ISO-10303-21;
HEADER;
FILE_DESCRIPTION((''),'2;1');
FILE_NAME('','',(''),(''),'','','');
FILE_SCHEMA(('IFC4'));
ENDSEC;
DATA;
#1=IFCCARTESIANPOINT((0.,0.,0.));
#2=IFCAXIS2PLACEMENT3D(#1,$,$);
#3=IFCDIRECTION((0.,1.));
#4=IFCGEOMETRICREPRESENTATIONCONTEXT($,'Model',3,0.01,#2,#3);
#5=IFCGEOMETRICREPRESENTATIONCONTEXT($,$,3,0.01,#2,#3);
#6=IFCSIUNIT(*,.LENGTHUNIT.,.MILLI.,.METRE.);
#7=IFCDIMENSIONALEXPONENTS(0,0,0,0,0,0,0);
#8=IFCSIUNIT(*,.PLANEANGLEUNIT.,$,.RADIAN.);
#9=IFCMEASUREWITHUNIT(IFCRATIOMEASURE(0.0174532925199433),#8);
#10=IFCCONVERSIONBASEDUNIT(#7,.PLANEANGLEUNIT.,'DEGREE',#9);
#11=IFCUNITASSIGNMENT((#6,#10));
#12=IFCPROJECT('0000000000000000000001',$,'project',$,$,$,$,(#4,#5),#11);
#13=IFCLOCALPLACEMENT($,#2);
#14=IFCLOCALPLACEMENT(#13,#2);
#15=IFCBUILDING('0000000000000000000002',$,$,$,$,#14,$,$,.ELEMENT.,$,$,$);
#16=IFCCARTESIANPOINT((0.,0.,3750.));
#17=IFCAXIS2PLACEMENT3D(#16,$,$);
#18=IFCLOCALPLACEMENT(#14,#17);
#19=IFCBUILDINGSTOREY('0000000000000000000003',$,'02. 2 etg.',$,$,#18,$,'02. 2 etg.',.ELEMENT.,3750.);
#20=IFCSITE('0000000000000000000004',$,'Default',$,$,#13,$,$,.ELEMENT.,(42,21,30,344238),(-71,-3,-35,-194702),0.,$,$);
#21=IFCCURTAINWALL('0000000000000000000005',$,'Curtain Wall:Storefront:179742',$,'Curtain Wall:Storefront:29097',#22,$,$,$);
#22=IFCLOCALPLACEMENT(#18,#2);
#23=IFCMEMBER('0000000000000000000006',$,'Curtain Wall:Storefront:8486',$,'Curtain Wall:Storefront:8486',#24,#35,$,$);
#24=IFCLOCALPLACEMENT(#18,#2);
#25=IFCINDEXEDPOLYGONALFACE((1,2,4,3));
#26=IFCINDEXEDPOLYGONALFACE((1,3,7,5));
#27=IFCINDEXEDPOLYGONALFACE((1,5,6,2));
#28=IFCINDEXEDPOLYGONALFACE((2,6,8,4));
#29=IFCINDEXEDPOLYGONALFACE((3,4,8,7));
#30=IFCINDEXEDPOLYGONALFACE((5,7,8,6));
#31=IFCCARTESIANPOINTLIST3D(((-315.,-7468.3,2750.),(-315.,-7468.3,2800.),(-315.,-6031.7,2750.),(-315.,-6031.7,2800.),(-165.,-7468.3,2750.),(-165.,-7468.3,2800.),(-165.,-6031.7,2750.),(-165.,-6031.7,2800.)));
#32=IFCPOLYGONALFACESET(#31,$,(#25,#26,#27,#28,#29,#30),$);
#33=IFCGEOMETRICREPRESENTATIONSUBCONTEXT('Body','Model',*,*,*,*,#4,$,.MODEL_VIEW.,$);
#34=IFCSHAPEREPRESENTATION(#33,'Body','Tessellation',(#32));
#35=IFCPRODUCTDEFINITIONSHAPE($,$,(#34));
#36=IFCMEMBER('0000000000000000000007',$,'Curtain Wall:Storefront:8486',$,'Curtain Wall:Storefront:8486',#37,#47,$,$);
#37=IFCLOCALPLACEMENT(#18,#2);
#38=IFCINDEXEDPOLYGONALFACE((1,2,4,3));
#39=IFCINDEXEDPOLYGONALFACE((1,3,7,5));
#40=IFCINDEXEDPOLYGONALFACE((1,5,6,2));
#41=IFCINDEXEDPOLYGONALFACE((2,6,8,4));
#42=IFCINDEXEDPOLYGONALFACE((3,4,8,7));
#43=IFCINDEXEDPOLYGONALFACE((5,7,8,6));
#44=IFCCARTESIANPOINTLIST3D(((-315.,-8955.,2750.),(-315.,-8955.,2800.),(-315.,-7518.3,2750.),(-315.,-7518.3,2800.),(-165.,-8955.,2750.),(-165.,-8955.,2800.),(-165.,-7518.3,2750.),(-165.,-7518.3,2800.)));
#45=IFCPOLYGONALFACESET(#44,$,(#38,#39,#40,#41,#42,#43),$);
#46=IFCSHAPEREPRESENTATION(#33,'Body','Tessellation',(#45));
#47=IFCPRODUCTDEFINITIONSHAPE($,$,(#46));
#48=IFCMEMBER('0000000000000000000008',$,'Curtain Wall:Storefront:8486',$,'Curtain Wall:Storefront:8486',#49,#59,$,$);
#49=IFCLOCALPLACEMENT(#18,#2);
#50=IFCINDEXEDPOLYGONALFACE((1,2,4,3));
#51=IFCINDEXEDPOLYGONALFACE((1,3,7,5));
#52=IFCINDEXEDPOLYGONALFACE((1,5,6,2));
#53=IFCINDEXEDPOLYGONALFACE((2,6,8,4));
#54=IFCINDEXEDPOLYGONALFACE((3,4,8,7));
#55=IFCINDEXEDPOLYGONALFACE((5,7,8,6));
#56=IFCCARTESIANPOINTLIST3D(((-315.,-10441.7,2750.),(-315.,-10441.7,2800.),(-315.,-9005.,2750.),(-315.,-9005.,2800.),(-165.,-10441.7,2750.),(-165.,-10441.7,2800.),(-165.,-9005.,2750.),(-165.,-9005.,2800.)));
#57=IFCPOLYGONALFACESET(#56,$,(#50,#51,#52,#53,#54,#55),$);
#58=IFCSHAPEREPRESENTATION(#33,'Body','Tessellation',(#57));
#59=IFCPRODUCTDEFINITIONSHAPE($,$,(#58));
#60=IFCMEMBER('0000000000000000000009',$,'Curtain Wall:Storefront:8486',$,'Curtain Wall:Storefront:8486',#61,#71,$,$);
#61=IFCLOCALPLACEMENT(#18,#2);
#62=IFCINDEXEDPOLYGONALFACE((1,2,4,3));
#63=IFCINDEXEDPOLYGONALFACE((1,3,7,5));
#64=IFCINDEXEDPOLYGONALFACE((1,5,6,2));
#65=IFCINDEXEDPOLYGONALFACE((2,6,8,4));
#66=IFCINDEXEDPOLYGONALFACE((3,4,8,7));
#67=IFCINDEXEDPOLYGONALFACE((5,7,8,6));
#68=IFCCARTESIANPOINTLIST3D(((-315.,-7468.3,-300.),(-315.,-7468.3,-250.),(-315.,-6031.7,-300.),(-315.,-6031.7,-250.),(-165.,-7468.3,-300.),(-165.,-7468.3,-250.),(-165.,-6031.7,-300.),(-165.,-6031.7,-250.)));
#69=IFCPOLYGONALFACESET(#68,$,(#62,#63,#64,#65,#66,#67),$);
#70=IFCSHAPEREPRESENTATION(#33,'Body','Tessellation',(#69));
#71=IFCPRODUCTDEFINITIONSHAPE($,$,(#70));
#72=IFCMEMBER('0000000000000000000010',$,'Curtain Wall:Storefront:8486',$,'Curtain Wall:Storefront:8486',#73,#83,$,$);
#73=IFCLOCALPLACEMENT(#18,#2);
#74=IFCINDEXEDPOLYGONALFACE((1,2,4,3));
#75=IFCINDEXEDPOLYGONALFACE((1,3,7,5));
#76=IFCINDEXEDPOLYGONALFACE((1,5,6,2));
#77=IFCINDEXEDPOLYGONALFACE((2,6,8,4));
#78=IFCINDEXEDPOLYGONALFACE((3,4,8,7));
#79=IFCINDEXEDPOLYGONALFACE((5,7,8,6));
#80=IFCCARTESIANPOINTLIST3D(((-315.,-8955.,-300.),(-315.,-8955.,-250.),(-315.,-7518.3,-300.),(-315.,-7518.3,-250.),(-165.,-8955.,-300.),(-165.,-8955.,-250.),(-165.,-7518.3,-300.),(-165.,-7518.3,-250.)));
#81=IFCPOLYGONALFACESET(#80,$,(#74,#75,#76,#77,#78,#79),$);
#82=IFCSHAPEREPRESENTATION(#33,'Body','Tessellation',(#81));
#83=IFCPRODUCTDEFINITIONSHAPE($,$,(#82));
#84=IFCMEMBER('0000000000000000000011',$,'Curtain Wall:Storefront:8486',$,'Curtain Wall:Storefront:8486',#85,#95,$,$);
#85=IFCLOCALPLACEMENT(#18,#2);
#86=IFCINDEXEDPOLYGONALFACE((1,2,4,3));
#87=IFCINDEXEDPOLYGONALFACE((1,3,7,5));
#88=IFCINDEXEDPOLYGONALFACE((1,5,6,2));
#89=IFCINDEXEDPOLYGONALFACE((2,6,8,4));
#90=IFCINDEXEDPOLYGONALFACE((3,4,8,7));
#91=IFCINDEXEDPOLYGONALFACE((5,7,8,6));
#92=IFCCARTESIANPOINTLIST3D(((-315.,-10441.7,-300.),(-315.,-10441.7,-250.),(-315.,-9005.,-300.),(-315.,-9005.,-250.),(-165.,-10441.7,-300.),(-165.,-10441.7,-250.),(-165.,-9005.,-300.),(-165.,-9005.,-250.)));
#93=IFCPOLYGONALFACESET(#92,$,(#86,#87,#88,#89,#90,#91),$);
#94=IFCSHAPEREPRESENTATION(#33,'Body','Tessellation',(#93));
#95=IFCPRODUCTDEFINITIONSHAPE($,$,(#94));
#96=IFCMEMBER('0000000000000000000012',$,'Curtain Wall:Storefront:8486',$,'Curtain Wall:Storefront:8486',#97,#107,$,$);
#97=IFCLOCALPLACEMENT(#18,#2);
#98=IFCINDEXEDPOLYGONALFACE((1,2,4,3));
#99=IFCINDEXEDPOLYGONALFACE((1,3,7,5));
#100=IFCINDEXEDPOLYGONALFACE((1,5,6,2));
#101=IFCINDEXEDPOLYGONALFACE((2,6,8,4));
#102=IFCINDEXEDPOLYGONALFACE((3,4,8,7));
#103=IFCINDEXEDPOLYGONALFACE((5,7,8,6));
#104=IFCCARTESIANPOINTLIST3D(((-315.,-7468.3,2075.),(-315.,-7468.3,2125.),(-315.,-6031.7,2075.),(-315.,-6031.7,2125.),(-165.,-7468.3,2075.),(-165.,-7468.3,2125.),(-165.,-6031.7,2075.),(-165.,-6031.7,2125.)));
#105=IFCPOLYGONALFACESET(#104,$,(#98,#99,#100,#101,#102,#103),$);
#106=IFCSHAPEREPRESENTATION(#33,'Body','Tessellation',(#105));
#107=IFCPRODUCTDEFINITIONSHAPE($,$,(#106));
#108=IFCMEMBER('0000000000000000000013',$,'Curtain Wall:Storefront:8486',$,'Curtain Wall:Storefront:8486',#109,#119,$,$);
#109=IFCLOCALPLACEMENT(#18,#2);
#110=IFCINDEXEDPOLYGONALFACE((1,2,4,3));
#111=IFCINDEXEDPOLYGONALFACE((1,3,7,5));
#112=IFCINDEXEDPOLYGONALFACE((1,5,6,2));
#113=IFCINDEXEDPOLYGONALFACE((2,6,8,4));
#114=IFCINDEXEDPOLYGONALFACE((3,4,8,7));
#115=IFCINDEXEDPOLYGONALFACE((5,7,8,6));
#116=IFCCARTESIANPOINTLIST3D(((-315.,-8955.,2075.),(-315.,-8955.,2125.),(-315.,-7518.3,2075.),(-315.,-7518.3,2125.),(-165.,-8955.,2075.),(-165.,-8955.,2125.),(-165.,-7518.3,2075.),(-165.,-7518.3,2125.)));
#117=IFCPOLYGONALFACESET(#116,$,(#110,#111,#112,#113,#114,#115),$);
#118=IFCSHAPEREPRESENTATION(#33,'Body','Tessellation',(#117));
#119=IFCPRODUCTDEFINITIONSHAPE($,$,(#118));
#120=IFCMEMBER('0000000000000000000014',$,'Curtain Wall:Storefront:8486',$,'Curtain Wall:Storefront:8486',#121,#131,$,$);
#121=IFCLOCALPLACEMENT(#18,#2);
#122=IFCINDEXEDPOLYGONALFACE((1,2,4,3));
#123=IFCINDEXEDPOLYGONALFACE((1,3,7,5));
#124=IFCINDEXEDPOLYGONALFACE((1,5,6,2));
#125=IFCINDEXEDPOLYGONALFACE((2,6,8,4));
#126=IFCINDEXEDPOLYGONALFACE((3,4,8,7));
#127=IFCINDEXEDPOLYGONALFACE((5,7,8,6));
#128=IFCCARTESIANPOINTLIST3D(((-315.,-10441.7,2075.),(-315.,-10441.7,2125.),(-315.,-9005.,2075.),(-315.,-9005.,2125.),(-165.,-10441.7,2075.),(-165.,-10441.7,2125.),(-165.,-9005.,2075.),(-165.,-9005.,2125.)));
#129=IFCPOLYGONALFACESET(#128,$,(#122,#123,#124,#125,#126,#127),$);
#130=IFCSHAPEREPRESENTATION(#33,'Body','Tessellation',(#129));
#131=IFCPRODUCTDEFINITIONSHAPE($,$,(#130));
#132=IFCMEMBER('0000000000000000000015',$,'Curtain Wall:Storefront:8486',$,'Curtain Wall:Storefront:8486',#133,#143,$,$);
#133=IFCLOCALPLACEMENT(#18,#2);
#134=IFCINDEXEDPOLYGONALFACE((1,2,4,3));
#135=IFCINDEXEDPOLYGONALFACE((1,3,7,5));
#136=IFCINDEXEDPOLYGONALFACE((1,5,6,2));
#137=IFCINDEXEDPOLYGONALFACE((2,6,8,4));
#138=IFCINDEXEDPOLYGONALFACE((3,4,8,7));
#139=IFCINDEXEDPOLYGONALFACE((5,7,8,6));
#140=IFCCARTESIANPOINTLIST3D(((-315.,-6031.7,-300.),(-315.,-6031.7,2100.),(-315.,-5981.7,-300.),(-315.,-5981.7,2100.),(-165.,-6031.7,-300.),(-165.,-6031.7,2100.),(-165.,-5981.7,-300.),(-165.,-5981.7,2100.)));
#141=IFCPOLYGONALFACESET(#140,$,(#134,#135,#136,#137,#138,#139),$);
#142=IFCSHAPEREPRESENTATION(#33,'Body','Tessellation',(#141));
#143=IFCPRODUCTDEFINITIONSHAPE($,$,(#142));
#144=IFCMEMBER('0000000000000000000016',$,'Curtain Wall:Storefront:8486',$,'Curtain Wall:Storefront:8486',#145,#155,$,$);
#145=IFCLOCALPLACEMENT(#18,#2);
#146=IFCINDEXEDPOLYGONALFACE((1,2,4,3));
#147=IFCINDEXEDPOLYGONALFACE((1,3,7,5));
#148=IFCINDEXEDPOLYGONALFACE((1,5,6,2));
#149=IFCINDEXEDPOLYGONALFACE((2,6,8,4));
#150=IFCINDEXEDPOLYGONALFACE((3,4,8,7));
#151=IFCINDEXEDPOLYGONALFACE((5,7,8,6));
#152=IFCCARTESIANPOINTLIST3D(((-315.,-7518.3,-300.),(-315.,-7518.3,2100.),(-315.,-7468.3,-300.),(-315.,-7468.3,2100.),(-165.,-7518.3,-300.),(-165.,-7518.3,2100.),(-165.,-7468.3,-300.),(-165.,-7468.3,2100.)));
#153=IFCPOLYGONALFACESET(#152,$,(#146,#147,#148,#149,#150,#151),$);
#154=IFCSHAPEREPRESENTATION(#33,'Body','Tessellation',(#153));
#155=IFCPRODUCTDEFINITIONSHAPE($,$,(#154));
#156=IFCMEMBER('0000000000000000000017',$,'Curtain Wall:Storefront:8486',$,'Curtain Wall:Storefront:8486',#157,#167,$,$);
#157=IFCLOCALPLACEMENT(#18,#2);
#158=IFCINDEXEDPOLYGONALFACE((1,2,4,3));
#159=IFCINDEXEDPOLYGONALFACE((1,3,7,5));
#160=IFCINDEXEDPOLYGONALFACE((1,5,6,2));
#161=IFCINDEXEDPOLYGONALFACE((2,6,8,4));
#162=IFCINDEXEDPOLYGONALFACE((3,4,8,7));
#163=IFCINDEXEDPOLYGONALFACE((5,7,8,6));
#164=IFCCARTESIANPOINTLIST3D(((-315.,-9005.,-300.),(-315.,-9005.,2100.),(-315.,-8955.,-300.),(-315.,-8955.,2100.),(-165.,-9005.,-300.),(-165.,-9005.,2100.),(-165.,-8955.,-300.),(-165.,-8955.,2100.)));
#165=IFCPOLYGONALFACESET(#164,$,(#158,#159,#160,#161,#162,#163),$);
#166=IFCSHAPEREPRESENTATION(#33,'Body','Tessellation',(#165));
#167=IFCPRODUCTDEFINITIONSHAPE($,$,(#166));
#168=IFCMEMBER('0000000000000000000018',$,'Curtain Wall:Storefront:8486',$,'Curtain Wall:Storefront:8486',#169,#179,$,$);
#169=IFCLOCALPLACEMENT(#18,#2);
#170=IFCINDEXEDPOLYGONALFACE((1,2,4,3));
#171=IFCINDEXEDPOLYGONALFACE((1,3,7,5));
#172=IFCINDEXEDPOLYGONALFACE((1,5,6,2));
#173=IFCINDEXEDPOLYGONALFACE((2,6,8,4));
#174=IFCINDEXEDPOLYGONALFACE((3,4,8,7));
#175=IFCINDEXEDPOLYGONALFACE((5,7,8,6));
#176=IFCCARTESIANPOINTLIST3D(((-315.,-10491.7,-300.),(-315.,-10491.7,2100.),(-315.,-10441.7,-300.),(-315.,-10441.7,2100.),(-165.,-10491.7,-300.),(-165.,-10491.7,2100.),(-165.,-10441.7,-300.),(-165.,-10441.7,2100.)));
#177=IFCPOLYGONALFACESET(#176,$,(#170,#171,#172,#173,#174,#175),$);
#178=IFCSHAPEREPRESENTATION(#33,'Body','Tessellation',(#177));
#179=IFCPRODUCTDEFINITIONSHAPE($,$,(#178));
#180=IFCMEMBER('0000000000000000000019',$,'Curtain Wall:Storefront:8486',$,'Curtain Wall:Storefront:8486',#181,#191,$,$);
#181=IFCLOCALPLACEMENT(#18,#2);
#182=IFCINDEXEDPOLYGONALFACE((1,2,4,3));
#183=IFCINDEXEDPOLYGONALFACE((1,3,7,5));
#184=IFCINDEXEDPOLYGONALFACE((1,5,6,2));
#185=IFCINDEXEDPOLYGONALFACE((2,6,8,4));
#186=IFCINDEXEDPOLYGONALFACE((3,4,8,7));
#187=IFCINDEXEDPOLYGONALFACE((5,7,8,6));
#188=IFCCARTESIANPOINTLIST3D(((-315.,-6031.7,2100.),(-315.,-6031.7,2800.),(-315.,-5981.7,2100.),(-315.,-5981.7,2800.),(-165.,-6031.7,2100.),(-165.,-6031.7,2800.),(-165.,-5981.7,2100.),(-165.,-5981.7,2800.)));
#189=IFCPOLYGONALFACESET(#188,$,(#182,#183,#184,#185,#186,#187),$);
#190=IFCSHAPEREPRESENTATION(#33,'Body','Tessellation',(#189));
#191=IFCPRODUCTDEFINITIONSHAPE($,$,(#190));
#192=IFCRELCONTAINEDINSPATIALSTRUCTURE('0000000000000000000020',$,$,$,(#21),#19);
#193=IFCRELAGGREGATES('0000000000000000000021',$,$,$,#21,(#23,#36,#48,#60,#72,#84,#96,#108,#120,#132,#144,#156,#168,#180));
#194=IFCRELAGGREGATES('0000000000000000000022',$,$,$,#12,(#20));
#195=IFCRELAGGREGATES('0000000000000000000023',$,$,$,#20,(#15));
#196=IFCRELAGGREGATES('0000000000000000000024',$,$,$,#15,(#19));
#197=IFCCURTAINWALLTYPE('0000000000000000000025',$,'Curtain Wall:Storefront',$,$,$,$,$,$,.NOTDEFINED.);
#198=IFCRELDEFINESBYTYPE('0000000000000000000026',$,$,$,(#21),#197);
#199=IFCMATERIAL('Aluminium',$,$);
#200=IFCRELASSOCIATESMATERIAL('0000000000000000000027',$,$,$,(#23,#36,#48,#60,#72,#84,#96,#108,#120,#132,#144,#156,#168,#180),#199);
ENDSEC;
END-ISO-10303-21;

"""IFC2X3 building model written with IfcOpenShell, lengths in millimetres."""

from ifc_helpers import new_model, entity, si_unit, converted_unit, direction, frame, frame_2d, origin, origin_2d_with_axis, place, context, subcontext, project, spatial, rectangle, extrude, material, type_object, element, aggregate, save


model = new_model("IFC2X3")

# Units and contexts
model_context = context("Model", 3, precision=0.01, world=origin(), true_north=direction((0.0, 1.0)))
context_of_model = context(None, 3, precision=0.01, world=origin(), true_north=direction((0.0, 1.0)))
body_context = subcontext(model_context, "Body", "Model", "MODEL_VIEW")
ifc_project = project(units=[si_unit("LENGTHUNIT", "METRE", prefix="MILLI"), converted_unit("PLANEANGLEUNIT", "DEGREE", entity("IfcRatioMeasure", 0.0174532925199433), si_unit("PLANEANGLEUNIT", "RADIAN"), dimensions=[0, 0, 0, 0, 0, 0, 0])], contexts=[model_context, context_of_model])

# Site, building, storey
site_placement = place(None, origin())
site = spatial("IfcSite", under=ifc_project, at=site_placement, Name="Default", CompositionType="ELEMENT", RefLatitude=(42, 21, 30, 344238), RefLongitude=(-71, -3, -35, -194702), RefElevation=0.0)
building_placement = place(site_placement, origin())
building = spatial("IfcBuilding", under=site, at=building_placement, CompositionType="ELEMENT")
storey_placement = place(building_placement, frame((0.0, 0.0, 3750.0)))
storey = spatial("IfcBuildingStorey", under=building, at=storey_placement, Name="02. 2 etg.", LongName="02. 2 etg.", CompositionType="ELEMENT", Elevation=3750.0)

# Curtain wall, members
curtain_wall_type = type_object("IfcCurtainWallType", Name="Curtain Wall:Storefront", PredefinedType="NOTDEFINED")
curtain_wall_placement = place(storey_placement, frame((0.0, 0.0, -3750.0)))
curtain_wall = element("IfcCurtainWall", 1, at=curtain_wall_placement, inside=storey, type_object=curtain_wall_type, Name="Curtain Wall:Storefront:179742", ObjectType="Curtain Wall:Storefront:29097")
ifc_material_1 = material(Name="Aluminium")
member_1_placement = place(curtain_wall_placement, frame((-315.0, -7468.3, 6500.0)))
member_1 = element("IfcMember", 2, at=member_1_placement, material=ifc_material_1, Name="Curtain Wall:Storefront:8486", ObjectType="Curtain Wall:Storefront:8486", context=body_context, shape_type="SweptSolid", body=[
    extrude(rectangle(XDim=1436.7, YDim=150.0, at=frame_2d((0.0, 0.0), x_axis=(1.0, 0.0))), frame((75.0, 718.3, 0.0), z_axis=(0.0, 0.0, 1.0), x_axis=(0.0, 1.0, 0.0)), (0.0, 0.0, 1.0), 50.0),
])
member_2_placement = place(curtain_wall_placement, frame((-315.0, -8955.0, 6500.0)))
member_2 = element("IfcMember", 3, at=member_2_placement, material=ifc_material_1, Name="Curtain Wall:Storefront:8486", ObjectType="Curtain Wall:Storefront:8486", context=body_context, shape_type="SweptSolid", body=[
    extrude(rectangle(XDim=1436.7, YDim=150.0, at=frame_2d((0.0, 0.0), x_axis=(1.0, 0.0))), frame((75.0, 718.3, 0.0), z_axis=(0.0, 0.0, 1.0), x_axis=(0.0, 1.0, 0.0)), (0.0, 0.0, 1.0), 50.0),
])
member_3_placement = place(curtain_wall_placement, frame((-315.0, -10441.7, 6500.0)))
member_3 = element("IfcMember", 4, at=member_3_placement, material=ifc_material_1, Name="Curtain Wall:Storefront:8486", ObjectType="Curtain Wall:Storefront:8486", context=body_context, shape_type="SweptSolid", body=[
    extrude(rectangle(XDim=1436.7, YDim=150.0, at=origin_2d_with_axis()), frame((75.0, 718.3, 0.0), z_axis=(0.0, 0.0, 1.0), x_axis=(0.0, 1.0, 0.0)), (0.0, 0.0, 1.0), 50.0),
])
member_4_placement = place(curtain_wall_placement, frame((-315.0, -7468.3, 3450.0)))
member_4 = element("IfcMember", 5, at=member_4_placement, material=ifc_material_1, Name="Curtain Wall:Storefront:8486", ObjectType="Curtain Wall:Storefront:8486", context=body_context, shape_type="SweptSolid", body=[
    extrude(rectangle(XDim=1436.7, YDim=150.0, at=frame_2d((0.0, 0.0), x_axis=(1.0, 0.0))), frame((75.0, 718.3, 0.0), z_axis=(0.0, 0.0, 1.0), x_axis=(0.0, -1.0, 0.0)), (0.0, 0.0, 1.0), 50.0),
])
member_5_placement = place(curtain_wall_placement, frame((-315.0, -8955.0, 3450.0)))
member_5 = element("IfcMember", 6, at=member_5_placement, material=ifc_material_1, Name="Curtain Wall:Storefront:8486", ObjectType="Curtain Wall:Storefront:8486", context=body_context, shape_type="SweptSolid", body=[
    extrude(rectangle(XDim=1436.7, YDim=150.0, at=frame_2d((0.0, 0.0), x_axis=(1.0, 0.0))), frame((75.0, 718.3, 0.0), z_axis=(0.0, 0.0, 1.0), x_axis=(0.0, -1.0, 0.0)), (0.0, 0.0, 1.0), 50.0),
])
member_6_placement = place(curtain_wall_placement, frame((-315.0, -10441.7, 3450.0)))
member_6 = element("IfcMember", 7, at=member_6_placement, material=ifc_material_1, Name="Curtain Wall:Storefront:8486", ObjectType="Curtain Wall:Storefront:8486", context=body_context, shape_type="SweptSolid", body=[
    extrude(rectangle(XDim=1436.7, YDim=150.0, at=frame_2d((0.0, 0.0), x_axis=(1.0, 0.0))), frame((75.0, 718.3, 0.0), z_axis=(0.0, 0.0, 1.0), x_axis=(0.0, -1.0, 0.0)), (0.0, 0.0, 1.0), 50.0),
])
member_7_placement = place(curtain_wall_placement, frame((-315.0, -7468.3, 5825.0)))
member_7 = element("IfcMember", 8, at=member_7_placement, material=ifc_material_1, Name="Curtain Wall:Storefront:8486", ObjectType="Curtain Wall:Storefront:8486", context=body_context, shape_type="SweptSolid", body=[
    extrude(rectangle(XDim=1436.7, YDim=150.0, at=frame_2d((0.0, 0.0), x_axis=(1.0, 0.0))), frame((75.0, 718.3, 0.0), z_axis=(0.0, 0.0, 1.0), x_axis=(0.0, 1.0, 0.0)), (0.0, 0.0, 1.0), 50.0),
])
member_8_placement = place(curtain_wall_placement, frame((-315.0, -8955.0, 5825.0)))
member_8 = element("IfcMember", 9, at=member_8_placement, material=ifc_material_1, Name="Curtain Wall:Storefront:8486", ObjectType="Curtain Wall:Storefront:8486", context=body_context, shape_type="SweptSolid", body=[
    extrude(rectangle(XDim=1436.7, YDim=150.0, at=frame_2d((0.0, 0.0), x_axis=(1.0, 0.0))), frame((75.0, 718.3, 0.0), z_axis=(0.0, 0.0, 1.0), x_axis=(0.0, 1.0, 0.0)), (0.0, 0.0, 1.0), 50.0),
])
member_9_placement = place(curtain_wall_placement, frame((-315.0, -10441.7, 5825.0)))
member_9 = element("IfcMember", 10, at=member_9_placement, material=ifc_material_1, Name="Curtain Wall:Storefront:8486", ObjectType="Curtain Wall:Storefront:8486", context=body_context, shape_type="SweptSolid", body=[
    extrude(rectangle(XDim=1436.7, YDim=150.0, at=origin_2d_with_axis()), frame((75.0, 718.3, 0.0), z_axis=(0.0, 0.0, 1.0), x_axis=(0.0, 1.0, 0.0)), (0.0, 0.0, 1.0), 50.0),
])
member_10_placement = place(curtain_wall_placement, frame((-315.0, -6031.7, 3450.0)))
member_10 = element("IfcMember", 11, at=member_10_placement, material=ifc_material_1, Name="Curtain Wall:Storefront:8486", ObjectType="Curtain Wall:Storefront:8486", context=body_context, shape_type="SweptSolid", body=[
    extrude(rectangle(XDim=150.0, YDim=50.0, at=frame_2d((0.0, 0.0), x_axis=(1.0, 0.0))), frame((75.0, 25.0, 0.0)), (0.0, 0.0, 1.0), 2400.0),
])
member_11_placement = place(curtain_wall_placement, frame((-315.0, -7518.3, 3450.0)))
member_11 = element("IfcMember", 12, at=member_11_placement, material=ifc_material_1, Name="Curtain Wall:Storefront:8486", ObjectType="Curtain Wall:Storefront:8486", context=body_context, shape_type="SweptSolid", body=[
    extrude(rectangle(XDim=150.0, YDim=50.0, at=frame_2d((0.0, 0.0), x_axis=(1.0, 0.0))), frame((75.0, 25.0, 0.0)), (0.0, 0.0, 1.0), 2400.0),
])
member_12_placement = place(curtain_wall_placement, frame((-315.0, -9005.0, 3450.0)))
member_12 = element("IfcMember", 13, at=member_12_placement, material=ifc_material_1, Name="Curtain Wall:Storefront:8486", ObjectType="Curtain Wall:Storefront:8486", context=body_context, shape_type="SweptSolid", body=[
    extrude(rectangle(XDim=150.0, YDim=50.0, at=frame_2d((0.0, 0.0), x_axis=(1.0, 0.0))), frame((75.0, 25.0, 0.0)), (0.0, 0.0, 1.0), 2400.0),
])
member_13_placement = place(curtain_wall_placement, frame((-315.0, -10491.7, 3450.0)))
member_13 = element("IfcMember", 14, at=member_13_placement, material=ifc_material_1, Name="Curtain Wall:Storefront:8486", ObjectType="Curtain Wall:Storefront:8486", context=body_context, shape_type="SweptSolid", body=[
    extrude(rectangle(XDim=150.0, YDim=50.0, at=frame_2d((0.0, 0.0), x_axis=(1.0, 0.0))), frame((75.0, 25.0, 0.0)), (0.0, 0.0, 1.0), 2400.0),
])
member_14_placement = place(curtain_wall_placement, frame((-315.0, -6031.7, 5850.0)))
member_14 = element("IfcMember", 15, at=member_14_placement, material=ifc_material_1, Name="Curtain Wall:Storefront:8486", ObjectType="Curtain Wall:Storefront:8486", context=body_context, shape_type="SweptSolid", body=[
    extrude(rectangle(XDim=150.0, YDim=50.0, at=frame_2d((0.0, 0.0), x_axis=(1.0, 0.0))), frame((75.0, 25.0, 0.0)), (0.0, 0.0, 1.0), 700.0),
])
aggregate(curtain_wall, [member_1, member_2, member_3, member_4, member_5, member_6, member_7, member_8, member_9, member_10, member_11, member_12, member_13, member_14])

save(model, "model.ifc")
